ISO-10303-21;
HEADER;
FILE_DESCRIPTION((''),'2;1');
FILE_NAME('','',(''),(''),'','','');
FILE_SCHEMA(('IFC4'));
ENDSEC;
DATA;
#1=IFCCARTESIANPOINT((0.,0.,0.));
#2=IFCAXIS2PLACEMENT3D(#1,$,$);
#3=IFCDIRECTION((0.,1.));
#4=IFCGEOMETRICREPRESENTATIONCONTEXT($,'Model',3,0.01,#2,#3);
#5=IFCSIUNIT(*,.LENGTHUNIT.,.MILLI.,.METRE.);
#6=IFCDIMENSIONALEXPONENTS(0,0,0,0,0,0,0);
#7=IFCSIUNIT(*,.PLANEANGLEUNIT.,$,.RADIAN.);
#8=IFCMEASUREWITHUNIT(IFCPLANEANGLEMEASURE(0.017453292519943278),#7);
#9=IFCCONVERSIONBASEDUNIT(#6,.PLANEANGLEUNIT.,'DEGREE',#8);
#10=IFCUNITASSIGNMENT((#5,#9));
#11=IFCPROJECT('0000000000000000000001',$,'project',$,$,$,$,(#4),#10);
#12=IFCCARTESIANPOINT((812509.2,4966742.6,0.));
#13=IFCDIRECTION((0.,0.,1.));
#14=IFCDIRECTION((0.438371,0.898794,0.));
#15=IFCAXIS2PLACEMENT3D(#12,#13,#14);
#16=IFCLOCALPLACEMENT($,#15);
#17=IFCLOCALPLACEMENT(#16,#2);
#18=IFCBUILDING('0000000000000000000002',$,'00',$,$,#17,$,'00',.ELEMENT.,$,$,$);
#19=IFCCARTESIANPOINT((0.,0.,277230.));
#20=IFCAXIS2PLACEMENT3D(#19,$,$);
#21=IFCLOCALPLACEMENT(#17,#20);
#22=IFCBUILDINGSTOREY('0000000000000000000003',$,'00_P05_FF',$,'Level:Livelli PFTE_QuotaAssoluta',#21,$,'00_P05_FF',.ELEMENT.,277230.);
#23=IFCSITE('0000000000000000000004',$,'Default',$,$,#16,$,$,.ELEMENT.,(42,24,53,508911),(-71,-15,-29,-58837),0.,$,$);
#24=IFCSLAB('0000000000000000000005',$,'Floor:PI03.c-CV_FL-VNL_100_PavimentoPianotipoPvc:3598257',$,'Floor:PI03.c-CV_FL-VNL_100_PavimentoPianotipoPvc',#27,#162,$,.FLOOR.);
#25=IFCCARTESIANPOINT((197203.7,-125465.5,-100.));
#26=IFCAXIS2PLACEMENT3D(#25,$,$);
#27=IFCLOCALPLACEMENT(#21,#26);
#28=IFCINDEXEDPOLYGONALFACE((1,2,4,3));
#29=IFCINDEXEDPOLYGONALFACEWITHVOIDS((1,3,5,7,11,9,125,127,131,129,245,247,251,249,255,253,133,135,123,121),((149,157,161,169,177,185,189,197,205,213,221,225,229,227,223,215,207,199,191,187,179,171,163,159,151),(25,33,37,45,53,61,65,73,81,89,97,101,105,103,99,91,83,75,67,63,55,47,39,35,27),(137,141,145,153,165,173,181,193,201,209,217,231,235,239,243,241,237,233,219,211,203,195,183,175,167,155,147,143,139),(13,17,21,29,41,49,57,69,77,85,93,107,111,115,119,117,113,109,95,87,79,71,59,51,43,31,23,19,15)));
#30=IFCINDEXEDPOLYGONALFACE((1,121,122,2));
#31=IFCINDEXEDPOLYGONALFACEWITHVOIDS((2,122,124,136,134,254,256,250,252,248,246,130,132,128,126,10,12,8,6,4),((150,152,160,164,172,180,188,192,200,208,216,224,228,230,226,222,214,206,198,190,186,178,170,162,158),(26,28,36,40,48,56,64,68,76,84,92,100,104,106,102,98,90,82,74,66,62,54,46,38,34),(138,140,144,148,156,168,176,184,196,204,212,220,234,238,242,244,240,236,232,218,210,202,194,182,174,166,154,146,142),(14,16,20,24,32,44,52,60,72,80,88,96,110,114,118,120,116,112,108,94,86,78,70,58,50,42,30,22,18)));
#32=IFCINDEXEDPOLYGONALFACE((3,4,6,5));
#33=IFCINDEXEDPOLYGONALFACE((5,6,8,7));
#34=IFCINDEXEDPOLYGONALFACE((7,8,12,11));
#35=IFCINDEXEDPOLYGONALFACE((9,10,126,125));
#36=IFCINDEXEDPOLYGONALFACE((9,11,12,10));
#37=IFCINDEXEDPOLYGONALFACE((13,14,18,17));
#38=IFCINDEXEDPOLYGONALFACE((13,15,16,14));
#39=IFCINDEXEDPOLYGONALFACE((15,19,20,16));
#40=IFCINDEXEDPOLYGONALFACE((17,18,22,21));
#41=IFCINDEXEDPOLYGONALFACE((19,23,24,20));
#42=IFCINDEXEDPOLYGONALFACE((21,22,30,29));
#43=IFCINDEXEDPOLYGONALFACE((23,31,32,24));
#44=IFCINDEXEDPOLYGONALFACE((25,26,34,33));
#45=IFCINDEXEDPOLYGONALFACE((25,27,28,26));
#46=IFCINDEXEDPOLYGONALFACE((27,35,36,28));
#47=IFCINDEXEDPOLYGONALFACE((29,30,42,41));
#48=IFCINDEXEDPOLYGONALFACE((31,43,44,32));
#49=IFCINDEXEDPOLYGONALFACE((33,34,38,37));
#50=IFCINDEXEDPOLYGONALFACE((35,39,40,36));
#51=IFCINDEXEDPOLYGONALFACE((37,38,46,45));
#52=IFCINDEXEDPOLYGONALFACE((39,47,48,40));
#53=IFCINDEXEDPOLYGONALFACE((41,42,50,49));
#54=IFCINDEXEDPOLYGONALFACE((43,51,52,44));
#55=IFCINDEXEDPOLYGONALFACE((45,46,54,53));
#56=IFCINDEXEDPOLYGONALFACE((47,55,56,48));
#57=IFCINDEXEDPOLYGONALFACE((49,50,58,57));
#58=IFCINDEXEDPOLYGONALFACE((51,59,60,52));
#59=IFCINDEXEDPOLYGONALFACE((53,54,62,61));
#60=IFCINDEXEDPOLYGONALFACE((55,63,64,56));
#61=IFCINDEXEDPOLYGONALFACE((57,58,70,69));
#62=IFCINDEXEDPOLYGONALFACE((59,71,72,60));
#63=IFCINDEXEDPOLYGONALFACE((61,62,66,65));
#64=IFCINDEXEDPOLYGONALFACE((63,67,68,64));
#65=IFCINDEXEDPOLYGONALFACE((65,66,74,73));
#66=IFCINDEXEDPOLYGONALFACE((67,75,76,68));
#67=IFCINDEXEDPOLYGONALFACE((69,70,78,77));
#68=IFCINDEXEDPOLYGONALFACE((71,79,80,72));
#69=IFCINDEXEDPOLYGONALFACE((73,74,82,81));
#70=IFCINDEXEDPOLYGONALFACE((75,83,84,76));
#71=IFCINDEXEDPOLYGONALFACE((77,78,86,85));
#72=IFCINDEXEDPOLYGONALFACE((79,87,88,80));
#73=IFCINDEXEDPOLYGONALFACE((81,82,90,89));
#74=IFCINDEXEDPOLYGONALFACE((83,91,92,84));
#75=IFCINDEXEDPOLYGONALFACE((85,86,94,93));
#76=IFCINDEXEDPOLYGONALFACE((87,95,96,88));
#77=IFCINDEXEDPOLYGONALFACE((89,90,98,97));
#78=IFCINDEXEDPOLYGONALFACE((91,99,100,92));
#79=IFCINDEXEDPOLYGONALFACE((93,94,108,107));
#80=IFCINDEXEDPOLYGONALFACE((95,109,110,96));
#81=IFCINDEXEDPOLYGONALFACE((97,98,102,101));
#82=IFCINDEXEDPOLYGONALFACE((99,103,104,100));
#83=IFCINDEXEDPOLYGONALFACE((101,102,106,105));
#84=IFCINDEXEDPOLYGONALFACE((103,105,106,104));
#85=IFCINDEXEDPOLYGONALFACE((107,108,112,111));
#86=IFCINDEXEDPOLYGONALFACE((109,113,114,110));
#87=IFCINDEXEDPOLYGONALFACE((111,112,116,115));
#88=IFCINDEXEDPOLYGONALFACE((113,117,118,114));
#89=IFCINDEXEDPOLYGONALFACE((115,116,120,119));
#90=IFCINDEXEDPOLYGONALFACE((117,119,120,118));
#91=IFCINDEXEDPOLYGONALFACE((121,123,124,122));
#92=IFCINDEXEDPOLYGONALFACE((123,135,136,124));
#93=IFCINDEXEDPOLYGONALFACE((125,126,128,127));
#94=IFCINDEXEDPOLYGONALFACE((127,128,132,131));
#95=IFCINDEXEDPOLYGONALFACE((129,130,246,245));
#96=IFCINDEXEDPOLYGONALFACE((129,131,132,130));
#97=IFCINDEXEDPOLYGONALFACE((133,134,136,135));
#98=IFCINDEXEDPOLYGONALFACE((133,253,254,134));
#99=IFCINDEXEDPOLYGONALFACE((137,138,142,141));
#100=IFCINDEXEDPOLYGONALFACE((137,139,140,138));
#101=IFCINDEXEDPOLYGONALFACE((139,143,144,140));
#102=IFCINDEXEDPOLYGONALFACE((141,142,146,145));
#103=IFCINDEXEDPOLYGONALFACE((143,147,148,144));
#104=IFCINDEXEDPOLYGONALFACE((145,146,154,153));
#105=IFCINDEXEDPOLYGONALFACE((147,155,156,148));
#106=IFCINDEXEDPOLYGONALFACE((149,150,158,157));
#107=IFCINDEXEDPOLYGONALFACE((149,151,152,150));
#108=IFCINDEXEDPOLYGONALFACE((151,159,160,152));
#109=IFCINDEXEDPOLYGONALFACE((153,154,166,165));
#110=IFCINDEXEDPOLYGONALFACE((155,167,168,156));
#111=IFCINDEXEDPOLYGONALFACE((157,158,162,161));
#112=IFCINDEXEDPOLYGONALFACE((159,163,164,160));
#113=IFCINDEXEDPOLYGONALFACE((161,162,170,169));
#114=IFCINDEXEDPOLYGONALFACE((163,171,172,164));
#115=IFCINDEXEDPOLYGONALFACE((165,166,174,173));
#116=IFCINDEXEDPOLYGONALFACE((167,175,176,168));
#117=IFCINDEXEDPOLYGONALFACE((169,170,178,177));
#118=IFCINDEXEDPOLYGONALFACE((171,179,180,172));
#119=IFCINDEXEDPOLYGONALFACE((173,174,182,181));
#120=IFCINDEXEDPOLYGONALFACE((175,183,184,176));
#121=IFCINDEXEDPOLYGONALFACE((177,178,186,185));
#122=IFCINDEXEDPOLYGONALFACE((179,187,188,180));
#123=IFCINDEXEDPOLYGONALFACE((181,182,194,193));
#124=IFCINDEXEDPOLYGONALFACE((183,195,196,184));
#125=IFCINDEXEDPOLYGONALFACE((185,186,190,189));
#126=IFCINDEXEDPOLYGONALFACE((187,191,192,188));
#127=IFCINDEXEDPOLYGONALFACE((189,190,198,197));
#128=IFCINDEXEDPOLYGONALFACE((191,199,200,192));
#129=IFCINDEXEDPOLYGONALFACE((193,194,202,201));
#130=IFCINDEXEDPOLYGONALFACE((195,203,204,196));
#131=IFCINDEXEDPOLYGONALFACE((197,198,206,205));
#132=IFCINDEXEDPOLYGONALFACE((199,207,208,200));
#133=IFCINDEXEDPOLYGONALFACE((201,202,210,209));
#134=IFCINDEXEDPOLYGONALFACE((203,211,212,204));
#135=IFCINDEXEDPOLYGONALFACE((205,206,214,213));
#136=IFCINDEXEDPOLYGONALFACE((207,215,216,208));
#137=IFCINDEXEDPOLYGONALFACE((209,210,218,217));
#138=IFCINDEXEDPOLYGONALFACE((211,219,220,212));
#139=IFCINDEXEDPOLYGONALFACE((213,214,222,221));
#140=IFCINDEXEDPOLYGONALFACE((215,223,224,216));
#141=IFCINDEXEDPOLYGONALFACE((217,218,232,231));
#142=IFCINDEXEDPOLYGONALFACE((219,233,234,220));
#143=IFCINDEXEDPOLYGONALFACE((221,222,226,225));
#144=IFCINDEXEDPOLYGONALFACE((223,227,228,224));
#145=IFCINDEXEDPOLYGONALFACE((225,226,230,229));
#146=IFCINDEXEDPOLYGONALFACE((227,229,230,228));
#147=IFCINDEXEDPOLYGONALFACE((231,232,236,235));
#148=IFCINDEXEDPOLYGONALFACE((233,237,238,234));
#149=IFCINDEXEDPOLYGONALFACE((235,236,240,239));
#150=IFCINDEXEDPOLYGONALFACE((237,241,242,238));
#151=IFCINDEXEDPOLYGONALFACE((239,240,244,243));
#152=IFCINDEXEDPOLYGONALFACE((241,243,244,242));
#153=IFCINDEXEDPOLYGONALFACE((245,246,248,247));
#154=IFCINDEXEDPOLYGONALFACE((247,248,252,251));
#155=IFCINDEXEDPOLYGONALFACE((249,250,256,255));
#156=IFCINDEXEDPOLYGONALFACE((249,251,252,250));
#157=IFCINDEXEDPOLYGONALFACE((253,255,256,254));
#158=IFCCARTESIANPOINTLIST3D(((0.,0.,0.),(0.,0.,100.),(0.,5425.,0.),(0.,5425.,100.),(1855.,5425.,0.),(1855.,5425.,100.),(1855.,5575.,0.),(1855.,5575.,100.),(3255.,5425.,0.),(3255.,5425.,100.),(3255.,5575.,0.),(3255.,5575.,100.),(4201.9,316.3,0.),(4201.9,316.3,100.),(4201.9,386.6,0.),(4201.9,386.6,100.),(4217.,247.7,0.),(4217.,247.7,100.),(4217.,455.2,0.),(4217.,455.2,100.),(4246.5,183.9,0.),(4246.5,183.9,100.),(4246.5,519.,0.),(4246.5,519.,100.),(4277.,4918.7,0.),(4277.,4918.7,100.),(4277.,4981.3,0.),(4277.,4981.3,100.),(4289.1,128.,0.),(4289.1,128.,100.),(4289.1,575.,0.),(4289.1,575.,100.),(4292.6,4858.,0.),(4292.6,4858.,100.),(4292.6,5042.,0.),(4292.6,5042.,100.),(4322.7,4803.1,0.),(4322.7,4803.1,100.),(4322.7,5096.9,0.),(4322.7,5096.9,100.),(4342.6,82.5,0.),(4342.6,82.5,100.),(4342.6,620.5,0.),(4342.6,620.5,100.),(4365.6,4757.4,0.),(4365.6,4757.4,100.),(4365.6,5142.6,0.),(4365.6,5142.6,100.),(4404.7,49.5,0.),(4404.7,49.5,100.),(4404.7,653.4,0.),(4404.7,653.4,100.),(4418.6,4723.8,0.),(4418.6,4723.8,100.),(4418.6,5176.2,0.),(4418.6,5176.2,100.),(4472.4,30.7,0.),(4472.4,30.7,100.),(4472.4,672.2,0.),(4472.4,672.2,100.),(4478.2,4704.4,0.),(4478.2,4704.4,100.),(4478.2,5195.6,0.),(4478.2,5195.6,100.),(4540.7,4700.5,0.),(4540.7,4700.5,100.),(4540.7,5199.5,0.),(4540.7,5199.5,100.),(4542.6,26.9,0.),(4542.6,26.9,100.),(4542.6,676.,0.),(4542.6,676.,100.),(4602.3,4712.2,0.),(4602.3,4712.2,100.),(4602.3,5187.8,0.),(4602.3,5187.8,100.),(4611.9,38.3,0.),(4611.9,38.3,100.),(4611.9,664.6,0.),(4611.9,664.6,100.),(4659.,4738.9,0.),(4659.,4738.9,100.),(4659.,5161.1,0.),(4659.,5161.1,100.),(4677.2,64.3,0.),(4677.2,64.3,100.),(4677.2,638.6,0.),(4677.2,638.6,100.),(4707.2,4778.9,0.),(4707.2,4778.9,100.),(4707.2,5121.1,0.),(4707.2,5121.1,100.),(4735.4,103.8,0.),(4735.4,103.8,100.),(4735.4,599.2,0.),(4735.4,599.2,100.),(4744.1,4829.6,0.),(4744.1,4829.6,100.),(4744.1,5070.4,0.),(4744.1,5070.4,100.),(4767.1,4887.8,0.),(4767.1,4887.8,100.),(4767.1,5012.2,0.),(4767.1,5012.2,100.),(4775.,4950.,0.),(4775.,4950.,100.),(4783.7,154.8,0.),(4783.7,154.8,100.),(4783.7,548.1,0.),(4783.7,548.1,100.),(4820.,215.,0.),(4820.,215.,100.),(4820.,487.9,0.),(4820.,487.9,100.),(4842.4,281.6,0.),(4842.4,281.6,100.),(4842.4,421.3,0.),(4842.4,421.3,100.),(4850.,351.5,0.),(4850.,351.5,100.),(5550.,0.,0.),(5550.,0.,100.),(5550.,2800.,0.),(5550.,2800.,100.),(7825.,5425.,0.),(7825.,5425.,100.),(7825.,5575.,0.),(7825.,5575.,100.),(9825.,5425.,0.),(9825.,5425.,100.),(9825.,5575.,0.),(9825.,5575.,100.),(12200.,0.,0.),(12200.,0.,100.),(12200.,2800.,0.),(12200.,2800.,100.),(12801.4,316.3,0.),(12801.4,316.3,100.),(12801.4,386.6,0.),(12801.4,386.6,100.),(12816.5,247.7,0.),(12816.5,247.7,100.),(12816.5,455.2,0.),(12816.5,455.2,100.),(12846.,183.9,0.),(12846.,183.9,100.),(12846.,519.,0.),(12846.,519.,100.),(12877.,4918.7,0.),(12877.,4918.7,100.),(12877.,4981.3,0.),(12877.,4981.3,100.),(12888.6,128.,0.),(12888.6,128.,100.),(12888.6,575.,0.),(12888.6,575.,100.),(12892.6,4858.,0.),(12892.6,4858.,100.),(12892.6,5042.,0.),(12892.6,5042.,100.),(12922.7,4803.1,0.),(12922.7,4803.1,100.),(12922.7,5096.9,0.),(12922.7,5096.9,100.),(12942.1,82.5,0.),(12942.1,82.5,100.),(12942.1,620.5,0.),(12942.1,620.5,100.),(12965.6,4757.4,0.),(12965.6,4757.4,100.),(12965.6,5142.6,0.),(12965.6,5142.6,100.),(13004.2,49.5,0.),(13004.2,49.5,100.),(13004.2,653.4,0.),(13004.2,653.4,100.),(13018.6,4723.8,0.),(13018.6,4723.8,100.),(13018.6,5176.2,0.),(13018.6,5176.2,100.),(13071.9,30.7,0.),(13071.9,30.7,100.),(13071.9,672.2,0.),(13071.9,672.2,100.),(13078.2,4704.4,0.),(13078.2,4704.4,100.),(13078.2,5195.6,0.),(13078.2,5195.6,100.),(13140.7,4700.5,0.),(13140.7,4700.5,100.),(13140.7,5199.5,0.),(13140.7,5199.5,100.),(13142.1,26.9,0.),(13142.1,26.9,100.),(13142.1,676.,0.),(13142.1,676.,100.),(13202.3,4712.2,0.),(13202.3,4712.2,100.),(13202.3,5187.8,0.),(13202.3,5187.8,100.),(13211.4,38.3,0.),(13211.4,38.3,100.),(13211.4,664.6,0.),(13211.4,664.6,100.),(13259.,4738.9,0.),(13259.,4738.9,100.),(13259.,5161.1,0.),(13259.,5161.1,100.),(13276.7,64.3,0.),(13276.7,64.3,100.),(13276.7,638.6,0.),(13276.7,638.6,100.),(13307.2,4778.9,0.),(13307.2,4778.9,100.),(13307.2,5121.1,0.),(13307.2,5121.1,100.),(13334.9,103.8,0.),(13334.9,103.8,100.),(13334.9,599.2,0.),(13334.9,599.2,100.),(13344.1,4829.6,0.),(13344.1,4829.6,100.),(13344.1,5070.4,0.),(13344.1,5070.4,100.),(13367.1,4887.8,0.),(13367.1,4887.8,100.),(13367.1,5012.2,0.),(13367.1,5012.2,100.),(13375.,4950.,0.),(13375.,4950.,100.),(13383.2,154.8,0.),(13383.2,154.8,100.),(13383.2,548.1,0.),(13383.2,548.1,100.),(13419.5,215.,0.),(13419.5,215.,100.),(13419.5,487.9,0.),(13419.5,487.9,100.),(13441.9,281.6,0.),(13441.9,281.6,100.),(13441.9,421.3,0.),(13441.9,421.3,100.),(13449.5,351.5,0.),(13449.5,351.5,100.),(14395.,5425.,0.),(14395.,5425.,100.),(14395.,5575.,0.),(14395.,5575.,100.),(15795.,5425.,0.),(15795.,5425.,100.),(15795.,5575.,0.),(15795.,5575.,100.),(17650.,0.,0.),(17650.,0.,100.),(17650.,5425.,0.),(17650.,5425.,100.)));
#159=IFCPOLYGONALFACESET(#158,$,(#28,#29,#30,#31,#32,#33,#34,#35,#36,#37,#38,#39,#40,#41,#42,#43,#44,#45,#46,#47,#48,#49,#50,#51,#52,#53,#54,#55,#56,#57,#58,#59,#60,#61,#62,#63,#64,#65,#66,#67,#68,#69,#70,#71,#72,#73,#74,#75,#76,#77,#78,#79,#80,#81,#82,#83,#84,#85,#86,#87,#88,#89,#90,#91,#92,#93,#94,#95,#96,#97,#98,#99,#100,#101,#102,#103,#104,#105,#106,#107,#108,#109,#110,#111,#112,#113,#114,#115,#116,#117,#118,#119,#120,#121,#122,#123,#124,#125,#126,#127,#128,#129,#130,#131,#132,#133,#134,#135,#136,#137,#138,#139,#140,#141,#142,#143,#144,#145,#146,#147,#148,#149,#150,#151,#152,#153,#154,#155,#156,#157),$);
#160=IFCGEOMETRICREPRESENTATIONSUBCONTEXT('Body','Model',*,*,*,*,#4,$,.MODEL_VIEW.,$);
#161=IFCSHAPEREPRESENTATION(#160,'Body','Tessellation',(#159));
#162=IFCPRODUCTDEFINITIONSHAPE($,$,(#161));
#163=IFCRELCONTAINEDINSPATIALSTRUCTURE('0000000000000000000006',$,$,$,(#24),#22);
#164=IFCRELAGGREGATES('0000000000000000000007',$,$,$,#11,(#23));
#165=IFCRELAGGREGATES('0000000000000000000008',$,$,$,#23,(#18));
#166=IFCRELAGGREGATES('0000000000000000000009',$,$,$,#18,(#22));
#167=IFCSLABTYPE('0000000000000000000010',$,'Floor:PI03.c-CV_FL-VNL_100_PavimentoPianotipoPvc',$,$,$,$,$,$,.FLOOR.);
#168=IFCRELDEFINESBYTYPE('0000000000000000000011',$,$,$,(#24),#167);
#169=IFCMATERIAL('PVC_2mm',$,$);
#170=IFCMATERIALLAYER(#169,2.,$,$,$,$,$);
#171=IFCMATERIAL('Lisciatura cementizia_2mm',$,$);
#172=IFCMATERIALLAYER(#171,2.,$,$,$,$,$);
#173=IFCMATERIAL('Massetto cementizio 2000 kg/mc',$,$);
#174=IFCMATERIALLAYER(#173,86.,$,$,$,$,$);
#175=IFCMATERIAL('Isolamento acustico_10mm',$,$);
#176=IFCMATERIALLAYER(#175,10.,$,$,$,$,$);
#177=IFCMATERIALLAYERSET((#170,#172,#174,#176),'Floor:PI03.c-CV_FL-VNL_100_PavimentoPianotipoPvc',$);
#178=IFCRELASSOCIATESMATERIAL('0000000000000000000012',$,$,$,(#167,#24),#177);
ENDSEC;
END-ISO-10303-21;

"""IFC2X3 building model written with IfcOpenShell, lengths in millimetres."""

from ifc_helpers import new_model, entity, si_unit, converted_unit, direction, frame, frame_2d, origin, origin_2d_with_axis, place, context, subcontext, project, spatial, polyline, circle, outline, extrude, material, layer, layer_set, layer_usage, type_object, element, save


model = new_model("IFC2X3")

# Units and contexts
model_context = context("Model", 3, precision=0.01, world=origin(), true_north=direction((0.0, 1.0)))
body_context = subcontext(model_context, "Body", "Model", "MODEL_VIEW")
ifc_project = project(units=[si_unit("LENGTHUNIT", "METRE", prefix="MILLI"), converted_unit("PLANEANGLEUNIT", "DEGREE", entity("IfcPlaneAngleMeasure", 0.017453292519943278), si_unit("PLANEANGLEUNIT", "RADIAN"), dimensions=[0, 0, 0, 0, 0, 0, 0])], contexts=[model_context])

# Site, building, storey
site_placement = place(None, frame((812509.2, 4966742.6, 0.0), z_axis=(0.0, 0.0, 1.0), x_axis=(0.438371, 0.898794, 0.0)))
site = spatial("IfcSite", under=ifc_project, at=site_placement, Name="Default", CompositionType="ELEMENT", RefLatitude=(42, 24, 53, 508911), RefLongitude=(-71, -15, -29, -58837), RefElevation=0.0)
building_placement = place(site_placement, origin())
building = spatial("IfcBuilding", under=site, at=building_placement, Name="00", LongName="00", CompositionType="ELEMENT")
storey_placement = place(building_placement, frame((0.0, 0.0, 277230.0)))
storey = spatial("IfcBuildingStorey", under=building, at=storey_placement, Name="00_P05_FF", ObjectType="Level:Livelli PFTE_QuotaAssoluta", LongName="00_P05_FF", CompositionType="ELEMENT", Elevation=277230.0)

# Slab, openings
ifc_material_1 = material(Name="Massetto cementizio 2000 kg/mc")
ifc_material_2 = material(Name="Isolamento acustico_10mm")
ifc_material_3 = material(Name="PVC_2mm")
ifc_layer_1 = layer(ifc_material_3, 2.0)
ifc_material_4 = material(Name="Lisciatura cementizia_2mm")
ifc_layer_2 = layer(ifc_material_4, 2.0)
ifc_layer_3 = layer(ifc_material_1, 86.0)
ifc_layer_4 = layer(ifc_material_2, 10.0)
ifc_layer_set_1 = layer_set([ifc_layer_1, ifc_layer_2, ifc_layer_3, ifc_layer_4], Name="Floor:PI03.c-CV_FL-VNL_100_PavimentoPianotipoPvc")
ifc_layer_usage_1 = layer_usage(ifc_layer_set_1, "AXIS3", "POSITIVE", 0.0)
slab_type_1 = type_object("IfcSlabType", Name="Floor:PI03.c-CV_FL-VNL_100_PavimentoPianotipoPvc", PredefinedType="FLOOR", material=ifc_layer_set_1)
slab_1_placement = place(storey_placement, frame((197203.7, -125465.5, -100.0)))
slab_1 = element("IfcSlab", 1, at=slab_1_placement, inside=storey, type_object=slab_type_1, material=ifc_layer_usage_1, Name="Floor:PI03.c-CV_FL-VNL_100_PavimentoPianotipoPvc:3598257", ObjectType="Floor:PI03.c-CV_FL-VNL_100_PavimentoPianotipoPvc", PredefinedType="FLOOR", context=body_context, shape_type="SweptSolid", body=[
    extrude(outline(polyline([(-6970.0, 2637.5), (-8825.0, 2637.5), (-8825.0, -2787.5), (-3375.0, -2787.5), (-3375.0, 12.5), (3275.0, 12.5), (3275.0, -2787.5), (8825.0, -2787.5), (8825.0, 2637.5), (6970.0, 2637.5), (6970.0, 2787.5), (5570.0, 2787.5), (5570.0, 2637.5), (1000.0, 2637.5), (1000.0, 2787.5), (-1000.0, 2787.5), (-1000.0, 2637.5), (-5570.0, 2637.5), (-5570.0, 2787.5), (-6970.0, 2787.5), (-6970.0, 2637.5)])), frame((8825.0, 2787.5, 100.0), z_axis=(0.0, 0.0, -1.0), x_axis=(-1.0, 0.0, 0.0)), (0.0, 0.0, 1.0), 100.0),
])
opening_1_placement = place(slab_1_placement, origin())
element("IfcOpeningElement", 2, at=opening_1_placement, cuts=slab_1, ObjectType="Opening", context=body_context, shape_type="SweptSolid", body=[
    extrude(circle(Radius=250.0, at=frame_2d((0.0, 0.0), x_axis=(1.0, 0.0))), frame((13125.0, 4950.0, 100.0), z_axis=(0.0, 0.0, -1.0), x_axis=(1.0, 0.0, 0.0)), (0.0, 0.0, 1.0), 100.0),
])
opening_2_placement = place(slab_1_placement, origin())
element("IfcOpeningElement", 3, at=opening_2_placement, cuts=slab_1, ObjectType="Opening", context=body_context, shape_type="SweptSolid", body=[
    extrude(circle(Radius=250.0, at=frame_2d((0.0, 0.0), x_axis=(1.0, 0.0))), frame((4525.0, 4950.0, 100.0), z_axis=(0.0, 0.0, -1.0), x_axis=(1.0, 0.0, 0.0)), (0.0, 0.0, 1.0), 100.0),
])
opening_3_placement = place(slab_1_placement, origin())
element("IfcOpeningElement", 4, at=opening_3_placement, cuts=slab_1, ObjectType="Opening", context=body_context, shape_type="SweptSolid", body=[
    extrude(circle(Radius=325.0, at=origin_2d_with_axis()), frame((4525.0, 351.5, 100.0), z_axis=(0.0, 0.0, -1.0), x_axis=(1.0, 0.0, 0.0)), (0.0, 0.0, 1.0), 100.0),
])
opening_4_placement = place(slab_1_placement, origin())
element("IfcOpeningElement", 5, at=opening_4_placement, cuts=slab_1, ObjectType="Opening", context=body_context, shape_type="SweptSolid", body=[
    extrude(circle(Radius=325.0, at=origin_2d_with_axis()), frame((13124.5, 351.5, 100.0), z_axis=(0.0, 0.0, -1.0), x_axis=(1.0, 0.0, 0.0)), (0.0, 0.0, 1.0), 100.0),
])

save(model, "model.ifc")
